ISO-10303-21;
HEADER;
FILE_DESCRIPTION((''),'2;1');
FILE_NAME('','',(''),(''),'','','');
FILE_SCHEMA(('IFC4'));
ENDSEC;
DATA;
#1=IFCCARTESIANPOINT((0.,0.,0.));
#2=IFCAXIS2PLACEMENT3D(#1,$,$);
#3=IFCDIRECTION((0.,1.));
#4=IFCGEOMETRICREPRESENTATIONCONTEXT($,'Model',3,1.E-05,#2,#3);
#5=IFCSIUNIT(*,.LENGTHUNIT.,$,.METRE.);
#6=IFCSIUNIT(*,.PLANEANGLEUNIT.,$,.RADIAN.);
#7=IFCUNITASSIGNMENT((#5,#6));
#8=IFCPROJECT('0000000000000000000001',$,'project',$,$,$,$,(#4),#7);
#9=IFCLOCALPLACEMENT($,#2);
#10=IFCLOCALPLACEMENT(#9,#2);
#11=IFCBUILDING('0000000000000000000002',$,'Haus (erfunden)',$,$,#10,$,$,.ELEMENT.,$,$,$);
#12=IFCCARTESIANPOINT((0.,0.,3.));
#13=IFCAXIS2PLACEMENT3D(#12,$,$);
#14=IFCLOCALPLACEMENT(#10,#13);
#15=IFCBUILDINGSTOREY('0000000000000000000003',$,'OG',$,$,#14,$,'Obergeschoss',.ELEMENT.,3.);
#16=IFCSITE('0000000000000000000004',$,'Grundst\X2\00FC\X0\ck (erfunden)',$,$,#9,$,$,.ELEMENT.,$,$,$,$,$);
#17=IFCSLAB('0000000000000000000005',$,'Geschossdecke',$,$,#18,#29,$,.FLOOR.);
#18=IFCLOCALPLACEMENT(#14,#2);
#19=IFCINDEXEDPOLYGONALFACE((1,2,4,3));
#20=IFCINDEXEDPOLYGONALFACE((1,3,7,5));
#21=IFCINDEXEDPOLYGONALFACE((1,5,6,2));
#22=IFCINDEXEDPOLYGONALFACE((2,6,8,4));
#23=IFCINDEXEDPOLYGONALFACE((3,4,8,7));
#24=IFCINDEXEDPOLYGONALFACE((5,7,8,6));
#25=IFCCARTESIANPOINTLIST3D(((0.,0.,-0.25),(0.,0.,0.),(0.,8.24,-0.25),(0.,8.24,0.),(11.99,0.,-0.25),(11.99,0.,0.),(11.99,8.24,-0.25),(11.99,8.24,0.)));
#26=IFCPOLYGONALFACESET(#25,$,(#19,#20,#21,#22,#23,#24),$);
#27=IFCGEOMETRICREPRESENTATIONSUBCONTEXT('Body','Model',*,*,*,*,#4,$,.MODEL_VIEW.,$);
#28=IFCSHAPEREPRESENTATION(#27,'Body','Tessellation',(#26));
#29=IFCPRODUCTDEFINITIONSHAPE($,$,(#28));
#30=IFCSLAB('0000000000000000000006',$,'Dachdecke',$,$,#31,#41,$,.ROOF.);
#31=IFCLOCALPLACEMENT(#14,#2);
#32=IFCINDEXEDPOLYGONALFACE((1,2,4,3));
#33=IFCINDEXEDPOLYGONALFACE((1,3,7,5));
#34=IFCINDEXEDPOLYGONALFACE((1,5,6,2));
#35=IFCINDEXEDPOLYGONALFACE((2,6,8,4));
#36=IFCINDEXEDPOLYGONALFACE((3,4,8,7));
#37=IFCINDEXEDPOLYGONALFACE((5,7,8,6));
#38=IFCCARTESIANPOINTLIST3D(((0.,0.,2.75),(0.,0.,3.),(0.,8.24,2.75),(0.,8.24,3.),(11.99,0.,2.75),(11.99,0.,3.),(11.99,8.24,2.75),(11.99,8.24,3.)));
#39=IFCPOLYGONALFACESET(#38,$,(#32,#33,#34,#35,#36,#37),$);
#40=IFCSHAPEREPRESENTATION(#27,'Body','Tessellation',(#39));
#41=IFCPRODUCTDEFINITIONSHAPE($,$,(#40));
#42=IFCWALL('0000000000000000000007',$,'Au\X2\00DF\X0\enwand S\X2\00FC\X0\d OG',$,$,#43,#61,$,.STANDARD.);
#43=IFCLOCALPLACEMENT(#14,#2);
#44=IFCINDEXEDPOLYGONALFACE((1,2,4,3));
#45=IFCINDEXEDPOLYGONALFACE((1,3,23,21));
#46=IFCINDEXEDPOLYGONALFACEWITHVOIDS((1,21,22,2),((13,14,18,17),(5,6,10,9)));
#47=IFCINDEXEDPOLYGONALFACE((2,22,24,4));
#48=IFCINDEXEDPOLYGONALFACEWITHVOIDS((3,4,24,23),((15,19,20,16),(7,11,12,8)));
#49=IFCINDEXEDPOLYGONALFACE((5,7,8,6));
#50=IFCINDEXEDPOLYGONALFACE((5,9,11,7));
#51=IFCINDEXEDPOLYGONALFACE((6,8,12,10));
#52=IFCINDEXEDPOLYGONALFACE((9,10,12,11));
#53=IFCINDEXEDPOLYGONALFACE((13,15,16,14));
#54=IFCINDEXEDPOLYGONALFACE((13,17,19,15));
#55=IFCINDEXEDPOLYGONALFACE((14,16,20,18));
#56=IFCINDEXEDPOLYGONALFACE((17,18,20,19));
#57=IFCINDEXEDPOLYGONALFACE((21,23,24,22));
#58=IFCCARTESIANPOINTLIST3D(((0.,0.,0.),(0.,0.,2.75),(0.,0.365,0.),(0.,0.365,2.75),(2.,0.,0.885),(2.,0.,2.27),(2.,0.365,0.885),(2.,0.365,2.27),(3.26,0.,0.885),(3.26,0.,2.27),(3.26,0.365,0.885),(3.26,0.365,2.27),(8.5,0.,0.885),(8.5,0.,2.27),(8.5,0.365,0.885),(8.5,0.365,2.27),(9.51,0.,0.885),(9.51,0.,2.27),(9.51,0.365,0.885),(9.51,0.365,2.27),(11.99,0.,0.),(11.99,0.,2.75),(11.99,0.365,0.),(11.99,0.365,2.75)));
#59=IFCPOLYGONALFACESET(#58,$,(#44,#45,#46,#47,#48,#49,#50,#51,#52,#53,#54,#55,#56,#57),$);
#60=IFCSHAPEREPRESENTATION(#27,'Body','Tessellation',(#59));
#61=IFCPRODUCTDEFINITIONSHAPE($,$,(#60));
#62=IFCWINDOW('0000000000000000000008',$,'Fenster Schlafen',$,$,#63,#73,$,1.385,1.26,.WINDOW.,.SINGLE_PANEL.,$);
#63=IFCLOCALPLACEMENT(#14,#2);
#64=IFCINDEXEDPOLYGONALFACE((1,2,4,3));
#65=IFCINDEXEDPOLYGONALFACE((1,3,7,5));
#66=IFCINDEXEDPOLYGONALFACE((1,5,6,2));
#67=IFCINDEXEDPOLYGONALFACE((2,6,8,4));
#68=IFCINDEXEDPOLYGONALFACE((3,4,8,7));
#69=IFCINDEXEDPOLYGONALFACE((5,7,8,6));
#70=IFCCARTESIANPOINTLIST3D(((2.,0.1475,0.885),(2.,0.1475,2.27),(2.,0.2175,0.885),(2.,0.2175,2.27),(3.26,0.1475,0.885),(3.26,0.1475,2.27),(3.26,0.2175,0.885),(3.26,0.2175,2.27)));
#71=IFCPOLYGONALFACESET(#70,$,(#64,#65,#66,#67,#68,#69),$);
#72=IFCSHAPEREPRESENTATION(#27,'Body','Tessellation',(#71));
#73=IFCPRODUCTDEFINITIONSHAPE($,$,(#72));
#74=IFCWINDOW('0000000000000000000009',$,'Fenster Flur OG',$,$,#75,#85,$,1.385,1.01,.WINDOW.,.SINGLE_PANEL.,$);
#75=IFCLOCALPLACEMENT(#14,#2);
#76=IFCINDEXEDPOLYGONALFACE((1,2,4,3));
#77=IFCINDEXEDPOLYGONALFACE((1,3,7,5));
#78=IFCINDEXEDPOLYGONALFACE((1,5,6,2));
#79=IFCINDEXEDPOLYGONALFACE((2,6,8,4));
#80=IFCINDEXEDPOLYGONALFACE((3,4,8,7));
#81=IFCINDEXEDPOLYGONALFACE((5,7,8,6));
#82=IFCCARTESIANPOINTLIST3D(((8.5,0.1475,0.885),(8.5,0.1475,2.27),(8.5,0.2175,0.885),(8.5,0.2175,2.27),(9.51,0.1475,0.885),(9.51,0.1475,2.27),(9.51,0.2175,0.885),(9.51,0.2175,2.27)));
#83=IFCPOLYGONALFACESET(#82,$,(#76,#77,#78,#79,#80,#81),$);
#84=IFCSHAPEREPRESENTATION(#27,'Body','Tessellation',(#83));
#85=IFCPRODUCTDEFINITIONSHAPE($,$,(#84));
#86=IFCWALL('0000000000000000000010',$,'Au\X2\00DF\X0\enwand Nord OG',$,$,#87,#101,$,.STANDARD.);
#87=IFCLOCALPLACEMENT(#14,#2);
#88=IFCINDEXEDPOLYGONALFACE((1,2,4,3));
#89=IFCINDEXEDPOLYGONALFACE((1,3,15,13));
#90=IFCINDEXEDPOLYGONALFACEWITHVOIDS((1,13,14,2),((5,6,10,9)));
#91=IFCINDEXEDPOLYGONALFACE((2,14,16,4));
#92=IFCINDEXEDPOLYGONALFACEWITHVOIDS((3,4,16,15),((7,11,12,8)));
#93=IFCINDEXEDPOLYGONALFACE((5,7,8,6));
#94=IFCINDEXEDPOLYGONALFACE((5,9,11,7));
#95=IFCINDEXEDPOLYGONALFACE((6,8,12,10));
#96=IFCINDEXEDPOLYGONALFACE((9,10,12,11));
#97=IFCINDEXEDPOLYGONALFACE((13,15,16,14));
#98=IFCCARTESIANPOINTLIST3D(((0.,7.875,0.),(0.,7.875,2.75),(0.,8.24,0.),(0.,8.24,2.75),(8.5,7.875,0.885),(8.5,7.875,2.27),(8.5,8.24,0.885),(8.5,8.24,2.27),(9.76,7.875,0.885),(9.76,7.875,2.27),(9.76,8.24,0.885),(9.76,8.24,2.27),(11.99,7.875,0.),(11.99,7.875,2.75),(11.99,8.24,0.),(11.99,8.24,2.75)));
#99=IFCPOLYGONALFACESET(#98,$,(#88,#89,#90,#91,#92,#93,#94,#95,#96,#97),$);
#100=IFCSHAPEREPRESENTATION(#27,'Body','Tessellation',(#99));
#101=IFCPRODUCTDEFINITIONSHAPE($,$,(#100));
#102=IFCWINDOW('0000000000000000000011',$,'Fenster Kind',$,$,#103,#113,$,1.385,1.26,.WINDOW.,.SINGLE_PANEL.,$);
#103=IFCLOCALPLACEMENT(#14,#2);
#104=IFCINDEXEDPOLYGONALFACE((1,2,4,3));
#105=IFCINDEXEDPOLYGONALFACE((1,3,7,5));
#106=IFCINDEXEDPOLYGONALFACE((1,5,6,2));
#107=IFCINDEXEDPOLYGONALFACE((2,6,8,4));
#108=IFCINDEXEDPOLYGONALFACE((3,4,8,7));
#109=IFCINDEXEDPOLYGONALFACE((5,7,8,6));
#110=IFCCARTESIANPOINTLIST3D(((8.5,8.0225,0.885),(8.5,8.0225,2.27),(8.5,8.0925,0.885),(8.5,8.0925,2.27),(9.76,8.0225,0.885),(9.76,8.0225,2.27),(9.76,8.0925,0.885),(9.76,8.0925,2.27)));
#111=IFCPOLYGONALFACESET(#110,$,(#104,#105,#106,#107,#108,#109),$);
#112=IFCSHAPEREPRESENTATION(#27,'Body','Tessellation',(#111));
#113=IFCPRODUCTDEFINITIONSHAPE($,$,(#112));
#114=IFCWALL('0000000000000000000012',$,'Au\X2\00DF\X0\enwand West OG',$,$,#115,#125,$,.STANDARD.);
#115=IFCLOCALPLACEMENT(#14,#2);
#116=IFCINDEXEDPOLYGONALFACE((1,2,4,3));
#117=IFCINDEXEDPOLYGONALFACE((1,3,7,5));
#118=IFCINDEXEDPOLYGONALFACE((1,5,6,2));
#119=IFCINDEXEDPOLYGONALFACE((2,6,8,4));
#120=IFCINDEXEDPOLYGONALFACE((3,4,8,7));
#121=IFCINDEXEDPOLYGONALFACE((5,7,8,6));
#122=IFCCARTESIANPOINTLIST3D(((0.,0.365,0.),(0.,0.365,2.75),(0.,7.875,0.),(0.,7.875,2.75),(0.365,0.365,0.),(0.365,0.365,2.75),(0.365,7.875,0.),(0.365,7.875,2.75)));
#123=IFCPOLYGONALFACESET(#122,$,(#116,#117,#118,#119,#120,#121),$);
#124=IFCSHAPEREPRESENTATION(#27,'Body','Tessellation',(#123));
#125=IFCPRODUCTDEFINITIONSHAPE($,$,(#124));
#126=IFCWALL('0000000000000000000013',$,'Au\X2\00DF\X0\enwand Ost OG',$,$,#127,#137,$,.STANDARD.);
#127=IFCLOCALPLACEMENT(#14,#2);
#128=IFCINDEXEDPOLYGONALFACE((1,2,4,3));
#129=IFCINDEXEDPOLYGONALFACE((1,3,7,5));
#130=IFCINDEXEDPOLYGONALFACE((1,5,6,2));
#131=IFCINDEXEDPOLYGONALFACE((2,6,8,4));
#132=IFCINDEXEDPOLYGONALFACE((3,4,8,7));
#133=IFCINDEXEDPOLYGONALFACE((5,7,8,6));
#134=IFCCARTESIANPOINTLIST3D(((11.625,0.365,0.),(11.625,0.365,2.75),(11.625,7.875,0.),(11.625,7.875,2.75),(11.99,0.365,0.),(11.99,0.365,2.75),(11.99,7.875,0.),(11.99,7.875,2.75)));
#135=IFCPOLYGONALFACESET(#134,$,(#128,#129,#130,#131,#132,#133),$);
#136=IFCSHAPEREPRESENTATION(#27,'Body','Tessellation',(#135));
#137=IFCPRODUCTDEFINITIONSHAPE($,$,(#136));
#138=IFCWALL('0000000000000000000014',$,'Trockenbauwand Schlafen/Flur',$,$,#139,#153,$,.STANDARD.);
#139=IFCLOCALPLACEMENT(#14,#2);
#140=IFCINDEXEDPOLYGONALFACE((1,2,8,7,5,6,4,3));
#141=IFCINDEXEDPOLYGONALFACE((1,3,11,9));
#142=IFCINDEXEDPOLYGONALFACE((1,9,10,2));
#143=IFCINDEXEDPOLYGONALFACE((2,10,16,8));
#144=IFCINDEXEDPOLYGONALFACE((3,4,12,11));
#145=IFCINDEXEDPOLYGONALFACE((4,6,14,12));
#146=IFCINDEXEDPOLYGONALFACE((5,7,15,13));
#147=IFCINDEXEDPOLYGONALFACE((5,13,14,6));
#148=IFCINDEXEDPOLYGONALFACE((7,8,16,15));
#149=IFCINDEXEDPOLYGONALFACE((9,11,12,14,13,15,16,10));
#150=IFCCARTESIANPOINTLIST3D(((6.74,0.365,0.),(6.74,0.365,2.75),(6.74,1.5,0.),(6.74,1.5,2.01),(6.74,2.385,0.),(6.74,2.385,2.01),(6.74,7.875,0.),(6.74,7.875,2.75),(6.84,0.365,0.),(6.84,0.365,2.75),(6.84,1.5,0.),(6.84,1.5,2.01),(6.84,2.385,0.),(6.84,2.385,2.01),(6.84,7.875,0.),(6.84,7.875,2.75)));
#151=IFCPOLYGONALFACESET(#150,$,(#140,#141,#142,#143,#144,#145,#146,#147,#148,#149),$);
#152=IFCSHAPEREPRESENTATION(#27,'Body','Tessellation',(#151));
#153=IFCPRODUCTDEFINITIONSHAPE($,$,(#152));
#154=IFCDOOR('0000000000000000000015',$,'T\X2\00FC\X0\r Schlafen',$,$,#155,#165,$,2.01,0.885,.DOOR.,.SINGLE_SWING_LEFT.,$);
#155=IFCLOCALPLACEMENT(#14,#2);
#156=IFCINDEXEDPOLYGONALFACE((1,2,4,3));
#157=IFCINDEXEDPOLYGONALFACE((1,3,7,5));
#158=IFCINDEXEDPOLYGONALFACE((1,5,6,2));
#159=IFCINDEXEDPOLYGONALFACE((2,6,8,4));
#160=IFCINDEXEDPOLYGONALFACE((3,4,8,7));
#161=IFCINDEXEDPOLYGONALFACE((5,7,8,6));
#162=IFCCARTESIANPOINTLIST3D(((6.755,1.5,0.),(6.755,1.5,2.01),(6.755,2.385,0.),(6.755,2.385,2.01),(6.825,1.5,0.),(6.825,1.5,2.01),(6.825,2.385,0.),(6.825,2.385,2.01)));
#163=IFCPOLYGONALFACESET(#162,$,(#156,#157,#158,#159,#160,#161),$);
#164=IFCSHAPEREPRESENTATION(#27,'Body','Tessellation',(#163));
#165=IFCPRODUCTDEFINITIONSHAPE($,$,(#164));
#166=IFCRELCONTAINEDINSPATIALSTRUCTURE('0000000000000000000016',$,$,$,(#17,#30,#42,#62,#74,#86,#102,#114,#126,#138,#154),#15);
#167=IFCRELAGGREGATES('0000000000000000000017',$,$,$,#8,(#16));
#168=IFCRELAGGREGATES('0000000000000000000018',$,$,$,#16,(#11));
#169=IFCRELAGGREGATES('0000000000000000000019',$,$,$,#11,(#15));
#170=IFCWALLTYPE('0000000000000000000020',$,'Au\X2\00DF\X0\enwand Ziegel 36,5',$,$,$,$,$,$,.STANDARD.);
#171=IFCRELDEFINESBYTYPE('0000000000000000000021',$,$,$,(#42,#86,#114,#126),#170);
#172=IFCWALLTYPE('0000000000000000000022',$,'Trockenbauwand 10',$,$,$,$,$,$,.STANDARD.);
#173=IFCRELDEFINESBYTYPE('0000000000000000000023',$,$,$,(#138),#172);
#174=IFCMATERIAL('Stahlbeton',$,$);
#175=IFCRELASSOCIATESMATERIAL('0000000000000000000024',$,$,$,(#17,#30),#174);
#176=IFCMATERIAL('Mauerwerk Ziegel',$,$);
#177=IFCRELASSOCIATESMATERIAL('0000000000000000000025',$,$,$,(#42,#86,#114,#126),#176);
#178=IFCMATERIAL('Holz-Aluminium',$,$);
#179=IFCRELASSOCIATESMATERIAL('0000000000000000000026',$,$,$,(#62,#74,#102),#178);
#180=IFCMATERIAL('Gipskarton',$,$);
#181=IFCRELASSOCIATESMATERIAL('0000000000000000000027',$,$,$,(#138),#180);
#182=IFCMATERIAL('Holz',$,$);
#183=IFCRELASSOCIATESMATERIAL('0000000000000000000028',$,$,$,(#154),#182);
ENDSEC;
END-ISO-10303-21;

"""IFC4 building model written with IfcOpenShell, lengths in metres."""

from ifc_helpers import new_model, si_unit, direction, frame, frame_2d, origin, place, context, subcontext, project, spatial, rectangle, extrude, material, type_object, element, fill, save


model = new_model("IFC4")

# Units and contexts
model_context = context("Model", 3, precision=1e-05, world=origin(), true_north=direction((0.0, 1.0)))
body_context = subcontext(model_context, "Body", "Model", "MODEL_VIEW")
ifc_project = project(units=[si_unit("LENGTHUNIT", "METRE"), si_unit("PLANEANGLEUNIT", "RADIAN")], contexts=[model_context])

# Site, building, storey
site_placement = place(None, origin())
site = spatial("IfcSite", under=ifc_project, at=site_placement, Name="Grundstück (erfunden)", CompositionType="ELEMENT")
building_placement = place(site_placement, origin())
building = spatial("IfcBuilding", under=site, at=building_placement, Name="Haus (erfunden)", CompositionType="ELEMENT")
storey_placement = place(building_placement, frame((0.0, 0.0, 3.0)))
storey = spatial("IfcBuildingStorey", under=building, at=storey_placement, Name="OG", LongName="Obergeschoss", CompositionType="ELEMENT", Elevation=3.0)

# Slabs
ifc_material_1 = material(Name="Stahlbeton")
slab_1_placement = place(storey_placement, frame((0.0, 0.0, -0.25)))
element("IfcSlab", 1, at=slab_1_placement, inside=storey, material=ifc_material_1, Name="Geschossdecke", PredefinedType="FLOOR", context=body_context, shape_type="SweptSolid", body=[
    extrude(rectangle(XDim=11.99, YDim=8.24, at=frame_2d((5.995, 4.12))), origin(), (0.0, 0.0, 1.0), 0.25),
])
slab_2_placement = place(storey_placement, frame((0.0, 0.0, 2.75)))
element("IfcSlab", 2, at=slab_2_placement, inside=storey, material=ifc_material_1, Name="Dachdecke", PredefinedType="ROOF", context=body_context, shape_type="SweptSolid", body=[
    extrude(rectangle(XDim=11.99, YDim=8.24, at=frame_2d((5.995, 4.12))), origin(), (0.0, 0.0, 1.0), 0.25),
])

# Wall, openings, windows
ifc_material_2 = material(Name="Mauerwerk Ziegel")
wall_type_1 = type_object("IfcWallType", Name="Außenwand Ziegel 36,5", PredefinedType="STANDARD")
wall_1_placement = place(storey_placement, origin())
wall_1 = element("IfcWall", 3, at=wall_1_placement, inside=storey, type_object=wall_type_1, material=ifc_material_2, Name="Außenwand Süd OG", PredefinedType="STANDARD", context=body_context, shape_type="SweptSolid", body=[
    extrude(rectangle(XDim=11.99, YDim=0.365, at=frame_2d((5.995, 0.1825))), origin(), (0.0, 0.0, 1.0), 2.75),
])
opening_1_placement = place(wall_1_placement, frame((2.0, -0.05, 0.885)))
opening_1 = element("IfcOpeningElement", 4, at=opening_1_placement, cuts=wall_1, PredefinedType="OPENING", context=body_context, shape_type="SweptSolid", body=[
    extrude(rectangle(XDim=1.26, YDim=0.465, at=frame_2d((0.63, 0.2325))), origin(), (0.0, 0.0, 1.0), 1.385),
])
opening_2_placement = place(wall_1_placement, frame((8.5, -0.05, 0.885)))
opening_2 = element("IfcOpeningElement", 5, at=opening_2_placement, cuts=wall_1, PredefinedType="OPENING", context=body_context, shape_type="SweptSolid", body=[
    extrude(rectangle(XDim=1.01, YDim=0.465, at=frame_2d((0.505, 0.2325))), origin(), (0.0, 0.0, 1.0), 1.385),
])
ifc_material_3 = material(Name="Holz-Aluminium")
window_1_placement = place(opening_1_placement, frame((0.0, 0.1975, 0.0)))
window_1 = element("IfcWindow", 6, at=window_1_placement, inside=storey, material=ifc_material_3, Name="Fenster Schlafen", OverallHeight=1.385, OverallWidth=1.26, PartitioningType="SINGLE_PANEL", PredefinedType="WINDOW", context=body_context, shape_type="SweptSolid", body=[
    extrude(rectangle(XDim=1.26, YDim=0.07, at=frame_2d((0.63, 0.035))), origin(), (0.0, 0.0, 1.0), 1.385),
])
fill(opening_1, window_1)
window_2_placement = place(opening_2_placement, frame((0.0, 0.1975, 0.0)))
window_2 = element("IfcWindow", 7, at=window_2_placement, inside=storey, material=ifc_material_3, Name="Fenster Flur OG", OverallHeight=1.385, OverallWidth=1.01, PartitioningType="SINGLE_PANEL", PredefinedType="WINDOW", context=body_context, shape_type="SweptSolid", body=[
    extrude(rectangle(XDim=1.01, YDim=0.07, at=frame_2d((0.505, 0.035))), origin(), (0.0, 0.0, 1.0), 1.385),
])
fill(opening_2, window_2)

# Wall, opening, window
wall_2_placement = place(storey_placement, frame((0.0, 7.875, 0.0)))
wall_2 = element("IfcWall", 8, at=wall_2_placement, inside=storey, type_object=wall_type_1, material=ifc_material_2, Name="Außenwand Nord OG", PredefinedType="STANDARD", context=body_context, shape_type="SweptSolid", body=[
    extrude(rectangle(XDim=11.99, YDim=0.365, at=frame_2d((5.995, 0.1825))), origin(), (0.0, 0.0, 1.0), 2.75),
])
opening_3_placement = place(wall_2_placement, frame((8.5, -0.05, 0.885)))
opening_3 = element("IfcOpeningElement", 9, at=opening_3_placement, cuts=wall_2, PredefinedType="OPENING", context=body_context, shape_type="SweptSolid", body=[
    extrude(rectangle(XDim=1.26, YDim=0.465, at=frame_2d((0.63, 0.2325))), origin(), (0.0, 0.0, 1.0), 1.385),
])
window_3_placement = place(opening_3_placement, frame((0.0, 0.1975, 0.0)))
window_3 = element("IfcWindow", 10, at=window_3_placement, inside=storey, material=ifc_material_3, Name="Fenster Kind", OverallHeight=1.385, OverallWidth=1.26, PartitioningType="SINGLE_PANEL", PredefinedType="WINDOW", context=body_context, shape_type="SweptSolid", body=[
    extrude(rectangle(XDim=1.26, YDim=0.07, at=frame_2d((0.63, 0.035))), origin(), (0.0, 0.0, 1.0), 1.385),
])
fill(opening_3, window_3)

# Walls
for number, where, name in (
    (11, (0.0, 0.365, 0.0), "Außenwand West OG"),
    (12, (11.625, 0.365, 0.0), "Außenwand Ost OG"),
):
    element("IfcWall", number, at=place(storey_placement, frame(where)), inside=storey, type_object=wall_type_1, material=ifc_material_2, Name=name, PredefinedType="STANDARD", context=body_context, shape_type="SweptSolid", body=[
        extrude(rectangle(XDim=0.365, YDim=7.51, at=frame_2d((0.1825, 3.755))), origin(), (0.0, 0.0, 1.0), 2.75),
    ])

# Wall, opening, door
ifc_material_4 = material(Name="Gipskarton")
wall_type_2 = type_object("IfcWallType", Name="Trockenbauwand 10", PredefinedType="STANDARD")
wall_3_placement = place(storey_placement, frame((6.74, 0.365, 0.0)))
wall_3 = element("IfcWall", 13, at=wall_3_placement, inside=storey, type_object=wall_type_2, material=ifc_material_4, Name="Trockenbauwand Schlafen/Flur", PredefinedType="STANDARD", context=body_context, shape_type="SweptSolid", body=[
    extrude(rectangle(XDim=0.1, YDim=7.51, at=frame_2d((0.05, 3.755))), origin(), (0.0, 0.0, 1.0), 2.75),
])
opening_4_placement = place(wall_3_placement, frame((-0.05, 1.135, 0.0)))
opening_4 = element("IfcOpeningElement", 14, at=opening_4_placement, cuts=wall_3, PredefinedType="OPENING", context=body_context, shape_type="SweptSolid", body=[
    extrude(rectangle(XDim=0.2, YDim=0.885, at=frame_2d((0.1, 0.4425))), origin(), (0.0, 0.0, 1.0), 2.01),
])
ifc_material_5 = material(Name="Holz")
door_1_placement = place(opening_4_placement, frame((0.065, 0.0, 0.0)))
door_1 = element("IfcDoor", 15, at=door_1_placement, inside=storey, material=ifc_material_5, Name="Tür Schlafen", OperationType="SINGLE_SWING_LEFT", OverallHeight=2.01, OverallWidth=0.885, PredefinedType="DOOR", context=body_context, shape_type="SweptSolid", body=[
    extrude(rectangle(XDim=0.07, YDim=0.885, at=frame_2d((0.035, 0.4425))), origin(), (0.0, 0.0, 1.0), 2.01),
])
fill(opening_4, door_1)

save(model, "model.ifc")
